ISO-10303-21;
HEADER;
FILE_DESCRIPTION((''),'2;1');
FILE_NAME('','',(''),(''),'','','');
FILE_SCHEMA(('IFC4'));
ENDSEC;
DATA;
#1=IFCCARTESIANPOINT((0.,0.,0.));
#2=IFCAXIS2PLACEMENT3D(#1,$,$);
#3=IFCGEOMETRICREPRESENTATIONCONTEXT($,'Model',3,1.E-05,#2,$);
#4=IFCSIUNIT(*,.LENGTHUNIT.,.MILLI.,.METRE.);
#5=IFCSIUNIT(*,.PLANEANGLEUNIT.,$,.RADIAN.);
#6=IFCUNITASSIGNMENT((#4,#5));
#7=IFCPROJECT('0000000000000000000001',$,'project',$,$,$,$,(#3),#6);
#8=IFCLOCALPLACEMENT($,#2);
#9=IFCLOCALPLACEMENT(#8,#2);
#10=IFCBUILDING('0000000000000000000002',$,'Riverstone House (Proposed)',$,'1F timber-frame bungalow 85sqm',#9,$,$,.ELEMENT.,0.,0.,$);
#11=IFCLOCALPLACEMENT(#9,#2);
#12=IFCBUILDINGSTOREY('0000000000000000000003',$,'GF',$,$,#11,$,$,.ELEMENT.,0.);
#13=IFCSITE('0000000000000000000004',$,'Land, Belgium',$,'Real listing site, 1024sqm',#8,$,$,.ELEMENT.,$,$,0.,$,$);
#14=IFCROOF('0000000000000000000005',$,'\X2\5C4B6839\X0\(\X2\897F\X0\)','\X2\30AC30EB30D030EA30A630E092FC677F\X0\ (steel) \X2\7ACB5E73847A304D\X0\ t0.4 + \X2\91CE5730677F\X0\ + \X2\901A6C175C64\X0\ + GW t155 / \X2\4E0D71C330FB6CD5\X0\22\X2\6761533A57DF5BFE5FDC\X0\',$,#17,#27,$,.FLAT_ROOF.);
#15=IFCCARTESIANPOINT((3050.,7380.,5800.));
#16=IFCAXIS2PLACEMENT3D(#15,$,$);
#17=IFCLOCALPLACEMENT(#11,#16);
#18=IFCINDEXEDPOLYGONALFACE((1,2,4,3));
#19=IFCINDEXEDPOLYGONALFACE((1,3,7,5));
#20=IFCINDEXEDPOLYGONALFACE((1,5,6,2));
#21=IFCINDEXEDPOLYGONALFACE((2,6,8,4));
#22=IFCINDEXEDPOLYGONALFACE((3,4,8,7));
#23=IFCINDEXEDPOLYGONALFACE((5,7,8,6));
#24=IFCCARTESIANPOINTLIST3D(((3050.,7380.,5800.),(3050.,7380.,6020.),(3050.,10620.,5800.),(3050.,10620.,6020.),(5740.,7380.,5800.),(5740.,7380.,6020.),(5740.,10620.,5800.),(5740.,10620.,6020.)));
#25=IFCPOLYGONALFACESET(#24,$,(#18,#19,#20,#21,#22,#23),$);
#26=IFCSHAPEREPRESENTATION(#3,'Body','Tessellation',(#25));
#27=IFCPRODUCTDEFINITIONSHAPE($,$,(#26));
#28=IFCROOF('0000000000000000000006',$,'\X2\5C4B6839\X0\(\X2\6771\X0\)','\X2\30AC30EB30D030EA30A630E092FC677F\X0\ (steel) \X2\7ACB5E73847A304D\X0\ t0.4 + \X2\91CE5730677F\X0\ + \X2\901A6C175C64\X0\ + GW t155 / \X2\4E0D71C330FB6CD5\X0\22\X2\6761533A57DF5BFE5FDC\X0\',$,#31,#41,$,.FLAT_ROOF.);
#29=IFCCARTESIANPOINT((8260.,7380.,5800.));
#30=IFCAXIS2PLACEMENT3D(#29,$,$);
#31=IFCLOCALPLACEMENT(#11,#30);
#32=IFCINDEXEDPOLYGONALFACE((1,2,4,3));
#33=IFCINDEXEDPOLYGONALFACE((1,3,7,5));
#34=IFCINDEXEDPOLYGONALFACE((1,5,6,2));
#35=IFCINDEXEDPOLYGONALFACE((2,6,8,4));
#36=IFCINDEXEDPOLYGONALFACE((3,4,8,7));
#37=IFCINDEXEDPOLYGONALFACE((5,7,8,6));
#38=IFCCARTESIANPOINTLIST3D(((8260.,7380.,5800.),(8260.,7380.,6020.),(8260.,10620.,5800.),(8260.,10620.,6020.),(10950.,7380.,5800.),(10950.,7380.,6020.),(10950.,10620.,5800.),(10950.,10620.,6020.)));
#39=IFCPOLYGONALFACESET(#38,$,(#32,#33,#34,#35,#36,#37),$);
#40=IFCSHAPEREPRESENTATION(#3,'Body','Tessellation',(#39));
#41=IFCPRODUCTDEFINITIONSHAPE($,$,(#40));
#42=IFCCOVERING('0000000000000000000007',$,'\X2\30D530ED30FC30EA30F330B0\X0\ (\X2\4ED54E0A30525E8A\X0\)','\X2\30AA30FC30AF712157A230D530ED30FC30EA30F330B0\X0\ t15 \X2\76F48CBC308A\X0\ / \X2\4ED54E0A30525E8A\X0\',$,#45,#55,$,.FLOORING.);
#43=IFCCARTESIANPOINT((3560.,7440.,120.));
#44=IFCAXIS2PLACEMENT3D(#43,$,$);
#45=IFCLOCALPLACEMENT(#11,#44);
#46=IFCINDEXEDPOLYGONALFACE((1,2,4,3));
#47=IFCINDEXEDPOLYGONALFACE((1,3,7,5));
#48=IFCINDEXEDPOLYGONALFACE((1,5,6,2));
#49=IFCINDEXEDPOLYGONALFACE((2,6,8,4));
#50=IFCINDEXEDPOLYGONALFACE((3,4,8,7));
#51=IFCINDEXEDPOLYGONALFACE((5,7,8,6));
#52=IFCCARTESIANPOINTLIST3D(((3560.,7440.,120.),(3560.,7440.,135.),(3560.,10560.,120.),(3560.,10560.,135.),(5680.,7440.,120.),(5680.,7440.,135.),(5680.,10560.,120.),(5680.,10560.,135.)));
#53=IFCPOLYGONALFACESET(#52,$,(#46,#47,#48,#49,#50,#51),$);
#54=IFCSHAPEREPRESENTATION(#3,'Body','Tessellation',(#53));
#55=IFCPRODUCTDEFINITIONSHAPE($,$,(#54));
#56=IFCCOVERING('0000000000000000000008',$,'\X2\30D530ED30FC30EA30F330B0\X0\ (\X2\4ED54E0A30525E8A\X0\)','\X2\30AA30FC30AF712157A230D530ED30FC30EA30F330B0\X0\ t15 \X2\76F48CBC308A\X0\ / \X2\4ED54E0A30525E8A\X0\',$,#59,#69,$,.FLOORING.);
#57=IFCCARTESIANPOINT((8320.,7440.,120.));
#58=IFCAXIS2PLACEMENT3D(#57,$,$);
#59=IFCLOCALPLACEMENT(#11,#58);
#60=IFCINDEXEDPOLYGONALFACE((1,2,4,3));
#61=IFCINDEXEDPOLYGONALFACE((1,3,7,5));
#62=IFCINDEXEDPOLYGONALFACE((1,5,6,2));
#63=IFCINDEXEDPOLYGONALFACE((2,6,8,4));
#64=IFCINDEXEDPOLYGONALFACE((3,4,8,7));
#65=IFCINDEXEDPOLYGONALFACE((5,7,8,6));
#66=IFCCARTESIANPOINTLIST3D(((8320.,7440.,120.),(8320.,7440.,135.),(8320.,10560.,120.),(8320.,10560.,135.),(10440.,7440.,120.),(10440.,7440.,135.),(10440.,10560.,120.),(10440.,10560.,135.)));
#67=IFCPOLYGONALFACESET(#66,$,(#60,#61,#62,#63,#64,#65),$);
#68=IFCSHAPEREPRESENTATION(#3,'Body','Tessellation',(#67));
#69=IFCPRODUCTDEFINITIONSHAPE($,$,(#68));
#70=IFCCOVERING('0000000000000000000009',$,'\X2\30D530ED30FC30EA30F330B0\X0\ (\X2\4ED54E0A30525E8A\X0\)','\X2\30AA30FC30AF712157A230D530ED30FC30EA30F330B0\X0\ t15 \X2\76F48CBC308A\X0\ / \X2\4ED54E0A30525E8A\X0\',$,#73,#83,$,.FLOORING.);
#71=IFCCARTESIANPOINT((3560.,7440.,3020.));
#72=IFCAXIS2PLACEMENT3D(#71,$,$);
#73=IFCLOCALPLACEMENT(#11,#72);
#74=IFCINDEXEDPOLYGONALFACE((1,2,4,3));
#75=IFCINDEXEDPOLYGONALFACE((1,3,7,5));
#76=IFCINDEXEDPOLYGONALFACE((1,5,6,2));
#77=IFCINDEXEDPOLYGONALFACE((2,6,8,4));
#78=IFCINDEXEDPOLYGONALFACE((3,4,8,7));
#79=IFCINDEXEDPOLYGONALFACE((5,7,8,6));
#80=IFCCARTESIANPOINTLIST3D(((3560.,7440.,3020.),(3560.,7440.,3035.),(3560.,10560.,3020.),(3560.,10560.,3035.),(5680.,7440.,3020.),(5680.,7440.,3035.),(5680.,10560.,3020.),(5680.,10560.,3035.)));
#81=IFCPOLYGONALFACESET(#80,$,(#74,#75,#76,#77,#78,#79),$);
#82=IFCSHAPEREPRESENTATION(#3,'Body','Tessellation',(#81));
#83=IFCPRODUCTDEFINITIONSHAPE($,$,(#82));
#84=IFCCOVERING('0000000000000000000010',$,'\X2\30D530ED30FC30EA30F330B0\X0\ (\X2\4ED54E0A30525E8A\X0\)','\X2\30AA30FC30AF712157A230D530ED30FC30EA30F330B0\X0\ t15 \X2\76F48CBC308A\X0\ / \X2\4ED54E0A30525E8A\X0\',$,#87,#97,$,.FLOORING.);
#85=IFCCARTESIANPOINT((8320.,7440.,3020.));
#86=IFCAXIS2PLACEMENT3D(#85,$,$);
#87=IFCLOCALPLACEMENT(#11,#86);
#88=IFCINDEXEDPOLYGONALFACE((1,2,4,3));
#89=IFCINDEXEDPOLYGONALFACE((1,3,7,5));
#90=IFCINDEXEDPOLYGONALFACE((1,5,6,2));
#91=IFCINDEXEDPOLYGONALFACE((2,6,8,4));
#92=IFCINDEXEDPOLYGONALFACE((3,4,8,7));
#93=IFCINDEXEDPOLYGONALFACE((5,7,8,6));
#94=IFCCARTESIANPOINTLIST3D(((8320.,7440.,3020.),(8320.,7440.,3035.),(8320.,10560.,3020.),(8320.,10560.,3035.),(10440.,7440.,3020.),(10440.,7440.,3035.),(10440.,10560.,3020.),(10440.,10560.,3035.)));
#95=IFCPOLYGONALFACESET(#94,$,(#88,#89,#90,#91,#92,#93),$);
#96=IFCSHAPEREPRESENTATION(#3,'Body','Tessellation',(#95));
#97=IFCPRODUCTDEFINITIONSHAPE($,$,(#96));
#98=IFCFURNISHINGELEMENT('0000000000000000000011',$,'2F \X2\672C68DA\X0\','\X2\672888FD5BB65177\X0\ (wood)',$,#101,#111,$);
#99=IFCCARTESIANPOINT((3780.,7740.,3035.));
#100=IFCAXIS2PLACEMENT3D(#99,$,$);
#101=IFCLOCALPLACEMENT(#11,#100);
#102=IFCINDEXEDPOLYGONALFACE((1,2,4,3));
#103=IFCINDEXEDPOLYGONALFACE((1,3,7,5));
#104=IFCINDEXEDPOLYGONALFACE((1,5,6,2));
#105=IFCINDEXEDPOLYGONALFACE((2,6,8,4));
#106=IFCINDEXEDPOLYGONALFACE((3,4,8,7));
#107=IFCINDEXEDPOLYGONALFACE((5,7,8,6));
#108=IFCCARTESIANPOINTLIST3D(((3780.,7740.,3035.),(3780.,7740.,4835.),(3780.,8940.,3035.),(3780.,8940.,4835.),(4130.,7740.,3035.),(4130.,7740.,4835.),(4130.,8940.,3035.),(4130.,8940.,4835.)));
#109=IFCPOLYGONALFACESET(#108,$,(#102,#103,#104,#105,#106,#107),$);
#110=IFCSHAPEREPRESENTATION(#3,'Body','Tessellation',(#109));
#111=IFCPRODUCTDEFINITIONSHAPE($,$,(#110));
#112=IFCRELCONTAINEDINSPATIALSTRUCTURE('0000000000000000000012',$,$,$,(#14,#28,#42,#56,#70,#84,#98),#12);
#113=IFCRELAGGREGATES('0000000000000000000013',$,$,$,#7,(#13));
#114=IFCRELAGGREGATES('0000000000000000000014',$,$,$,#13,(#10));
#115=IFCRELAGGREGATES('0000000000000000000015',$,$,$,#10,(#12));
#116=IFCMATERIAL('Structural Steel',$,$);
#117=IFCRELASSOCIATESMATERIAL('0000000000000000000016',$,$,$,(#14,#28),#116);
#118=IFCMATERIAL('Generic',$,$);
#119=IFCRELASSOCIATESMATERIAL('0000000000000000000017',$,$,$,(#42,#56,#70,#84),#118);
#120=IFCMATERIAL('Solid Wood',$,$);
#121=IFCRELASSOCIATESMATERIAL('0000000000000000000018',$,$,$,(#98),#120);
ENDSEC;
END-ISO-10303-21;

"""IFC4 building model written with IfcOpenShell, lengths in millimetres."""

from ifc_helpers import new_model, si_unit, frame, frame_2d, origin, place, context, project, spatial, rectangle, extrude, material, element, save


model = new_model("IFC4")

# Units and contexts
model_context = context("Model", 3, precision=1e-05, world=origin())
ifc_project = project(units=[si_unit("LENGTHUNIT", "METRE", prefix="MILLI"), si_unit("PLANEANGLEUNIT", "RADIAN")], contexts=[model_context])

# Site, building, storey
site_placement = place(None, origin())
site = spatial("IfcSite", under=ifc_project, at=site_placement, Name="Land, Belgium", ObjectType="Real listing site, 1024sqm", CompositionType="ELEMENT", RefElevation=0.0)
building_placement = place(site_placement, origin())
building = spatial("IfcBuilding", under=site, at=building_placement, Name="Riverstone House (Proposed)", ObjectType="1F timber-frame bungalow 85sqm", CompositionType="ELEMENT", ElevationOfRefHeight=0.0, ElevationOfTerrain=0.0)
storey_placement = place(building_placement, origin())
storey = spatial("IfcBuildingStorey", under=building, at=storey_placement, Name="GF", CompositionType="ELEMENT", Elevation=0.0)

# Shared definitions
ifc_material_1 = material(Name="Solid Wood")

# Roofs
ifc_material_2 = material(Name="Structural Steel")
roof_1_placement = place(storey_placement, frame((3050.0, 7380.0, 5800.0)))
element("IfcRoof", 1, at=roof_1_placement, inside=storey, material=ifc_material_2, Name="屋根(西)", Description="ガルバリウム鋼板 (steel) 立平葺き t0.4 + 野地板 + 通気層 + GW t155 / 不燃・法22条区域対応", PredefinedType="FLAT_ROOF", context=model_context, shape_type="SweptSolid", body=[
    extrude(rectangle(XDim=2690.0, YDim=3240.0, at=frame_2d((1345.0, 1620.0))), frame((3050.0, 7380.0, 5800.0)), (0.0, 0.0, 1.0), 220.0),
])
roof_2_placement = place(storey_placement, frame((8260.0, 7380.0, 5800.0)))
element("IfcRoof", 2, at=roof_2_placement, inside=storey, material=ifc_material_2, Name="屋根(東)", Description="ガルバリウム鋼板 (steel) 立平葺き t0.4 + 野地板 + 通気層 + GW t155 / 不燃・法22条区域対応", PredefinedType="FLAT_ROOF", context=model_context, shape_type="SweptSolid", body=[
    extrude(rectangle(XDim=2690.0, YDim=3240.0, at=frame_2d((1345.0, 1620.0))), frame((8260.0, 7380.0, 5800.0)), (0.0, 0.0, 1.0), 220.0),
])

# Coverings
ifc_material_3 = material(Name="Generic")
covering_1_placement = place(storey_placement, frame((3560.0, 7440.0, 120.0)))
element("IfcCovering", 3, at=covering_1_placement, inside=storey, material=ifc_material_3, Name="フローリング (仕上げ床)", Description="オーク無垢フローリング t15 直貼り / 仕上げ床", PredefinedType="FLOORING", context=model_context, shape_type="SweptSolid", body=[
    extrude(rectangle(XDim=2120.0, YDim=3120.0, at=frame_2d((1060.0, 1560.0))), frame((3560.0, 7440.0, 120.0)), (0.0, 0.0, 1.0), 15.0),
])
covering_2_placement = place(storey_placement, frame((8320.0, 7440.0, 120.0)))
element("IfcCovering", 4, at=covering_2_placement, inside=storey, material=ifc_material_3, Name="フローリング (仕上げ床)", Description="オーク無垢フローリング t15 直貼り / 仕上げ床", PredefinedType="FLOORING", context=model_context, shape_type="SweptSolid", body=[
    extrude(rectangle(XDim=2120.0, YDim=3120.0, at=frame_2d((1060.0, 1560.0))), frame((8320.0, 7440.0, 120.0)), (0.0, 0.0, 1.0), 15.0),
])
covering_3_placement = place(storey_placement, frame((3560.0, 7440.0, 3020.0)))
element("IfcCovering", 5, at=covering_3_placement, inside=storey, material=ifc_material_3, Name="フローリング (仕上げ床)", Description="オーク無垢フローリング t15 直貼り / 仕上げ床", PredefinedType="FLOORING", context=model_context, shape_type="SweptSolid", body=[
    extrude(rectangle(XDim=2120.0, YDim=3120.0, at=frame_2d((1060.0, 1560.0))), frame((3560.0, 7440.0, 3020.0)), (0.0, 0.0, 1.0), 15.0),
])
covering_4_placement = place(storey_placement, frame((8320.0, 7440.0, 3020.0)))
element("IfcCovering", 6, at=covering_4_placement, inside=storey, material=ifc_material_3, Name="フローリング (仕上げ床)", Description="オーク無垢フローリング t15 直貼り / 仕上げ床", PredefinedType="FLOORING", context=model_context, shape_type="SweptSolid", body=[
    extrude(rectangle(XDim=2120.0, YDim=3120.0, at=frame_2d((1060.0, 1560.0))), frame((8320.0, 7440.0, 3020.0)), (0.0, 0.0, 1.0), 15.0),
])

# Furnishing element
furnishing_placement = place(storey_placement, frame((3780.0, 7740.0, 3035.0)))
element("IfcFurnishingElement", 7, at=furnishing_placement, inside=storey, material=ifc_material_1, Name="2F 本棚", Description="木製家具 (wood)", context=model_context, shape_type="SweptSolid", body=[
    extrude(rectangle(XDim=350.0, YDim=1200.0, at=frame_2d((175.0, 600.0))), frame((3780.0, 7740.0, 3035.0)), (0.0, 0.0, 1.0), 1800.0),
])

save(model, "model.ifc")
